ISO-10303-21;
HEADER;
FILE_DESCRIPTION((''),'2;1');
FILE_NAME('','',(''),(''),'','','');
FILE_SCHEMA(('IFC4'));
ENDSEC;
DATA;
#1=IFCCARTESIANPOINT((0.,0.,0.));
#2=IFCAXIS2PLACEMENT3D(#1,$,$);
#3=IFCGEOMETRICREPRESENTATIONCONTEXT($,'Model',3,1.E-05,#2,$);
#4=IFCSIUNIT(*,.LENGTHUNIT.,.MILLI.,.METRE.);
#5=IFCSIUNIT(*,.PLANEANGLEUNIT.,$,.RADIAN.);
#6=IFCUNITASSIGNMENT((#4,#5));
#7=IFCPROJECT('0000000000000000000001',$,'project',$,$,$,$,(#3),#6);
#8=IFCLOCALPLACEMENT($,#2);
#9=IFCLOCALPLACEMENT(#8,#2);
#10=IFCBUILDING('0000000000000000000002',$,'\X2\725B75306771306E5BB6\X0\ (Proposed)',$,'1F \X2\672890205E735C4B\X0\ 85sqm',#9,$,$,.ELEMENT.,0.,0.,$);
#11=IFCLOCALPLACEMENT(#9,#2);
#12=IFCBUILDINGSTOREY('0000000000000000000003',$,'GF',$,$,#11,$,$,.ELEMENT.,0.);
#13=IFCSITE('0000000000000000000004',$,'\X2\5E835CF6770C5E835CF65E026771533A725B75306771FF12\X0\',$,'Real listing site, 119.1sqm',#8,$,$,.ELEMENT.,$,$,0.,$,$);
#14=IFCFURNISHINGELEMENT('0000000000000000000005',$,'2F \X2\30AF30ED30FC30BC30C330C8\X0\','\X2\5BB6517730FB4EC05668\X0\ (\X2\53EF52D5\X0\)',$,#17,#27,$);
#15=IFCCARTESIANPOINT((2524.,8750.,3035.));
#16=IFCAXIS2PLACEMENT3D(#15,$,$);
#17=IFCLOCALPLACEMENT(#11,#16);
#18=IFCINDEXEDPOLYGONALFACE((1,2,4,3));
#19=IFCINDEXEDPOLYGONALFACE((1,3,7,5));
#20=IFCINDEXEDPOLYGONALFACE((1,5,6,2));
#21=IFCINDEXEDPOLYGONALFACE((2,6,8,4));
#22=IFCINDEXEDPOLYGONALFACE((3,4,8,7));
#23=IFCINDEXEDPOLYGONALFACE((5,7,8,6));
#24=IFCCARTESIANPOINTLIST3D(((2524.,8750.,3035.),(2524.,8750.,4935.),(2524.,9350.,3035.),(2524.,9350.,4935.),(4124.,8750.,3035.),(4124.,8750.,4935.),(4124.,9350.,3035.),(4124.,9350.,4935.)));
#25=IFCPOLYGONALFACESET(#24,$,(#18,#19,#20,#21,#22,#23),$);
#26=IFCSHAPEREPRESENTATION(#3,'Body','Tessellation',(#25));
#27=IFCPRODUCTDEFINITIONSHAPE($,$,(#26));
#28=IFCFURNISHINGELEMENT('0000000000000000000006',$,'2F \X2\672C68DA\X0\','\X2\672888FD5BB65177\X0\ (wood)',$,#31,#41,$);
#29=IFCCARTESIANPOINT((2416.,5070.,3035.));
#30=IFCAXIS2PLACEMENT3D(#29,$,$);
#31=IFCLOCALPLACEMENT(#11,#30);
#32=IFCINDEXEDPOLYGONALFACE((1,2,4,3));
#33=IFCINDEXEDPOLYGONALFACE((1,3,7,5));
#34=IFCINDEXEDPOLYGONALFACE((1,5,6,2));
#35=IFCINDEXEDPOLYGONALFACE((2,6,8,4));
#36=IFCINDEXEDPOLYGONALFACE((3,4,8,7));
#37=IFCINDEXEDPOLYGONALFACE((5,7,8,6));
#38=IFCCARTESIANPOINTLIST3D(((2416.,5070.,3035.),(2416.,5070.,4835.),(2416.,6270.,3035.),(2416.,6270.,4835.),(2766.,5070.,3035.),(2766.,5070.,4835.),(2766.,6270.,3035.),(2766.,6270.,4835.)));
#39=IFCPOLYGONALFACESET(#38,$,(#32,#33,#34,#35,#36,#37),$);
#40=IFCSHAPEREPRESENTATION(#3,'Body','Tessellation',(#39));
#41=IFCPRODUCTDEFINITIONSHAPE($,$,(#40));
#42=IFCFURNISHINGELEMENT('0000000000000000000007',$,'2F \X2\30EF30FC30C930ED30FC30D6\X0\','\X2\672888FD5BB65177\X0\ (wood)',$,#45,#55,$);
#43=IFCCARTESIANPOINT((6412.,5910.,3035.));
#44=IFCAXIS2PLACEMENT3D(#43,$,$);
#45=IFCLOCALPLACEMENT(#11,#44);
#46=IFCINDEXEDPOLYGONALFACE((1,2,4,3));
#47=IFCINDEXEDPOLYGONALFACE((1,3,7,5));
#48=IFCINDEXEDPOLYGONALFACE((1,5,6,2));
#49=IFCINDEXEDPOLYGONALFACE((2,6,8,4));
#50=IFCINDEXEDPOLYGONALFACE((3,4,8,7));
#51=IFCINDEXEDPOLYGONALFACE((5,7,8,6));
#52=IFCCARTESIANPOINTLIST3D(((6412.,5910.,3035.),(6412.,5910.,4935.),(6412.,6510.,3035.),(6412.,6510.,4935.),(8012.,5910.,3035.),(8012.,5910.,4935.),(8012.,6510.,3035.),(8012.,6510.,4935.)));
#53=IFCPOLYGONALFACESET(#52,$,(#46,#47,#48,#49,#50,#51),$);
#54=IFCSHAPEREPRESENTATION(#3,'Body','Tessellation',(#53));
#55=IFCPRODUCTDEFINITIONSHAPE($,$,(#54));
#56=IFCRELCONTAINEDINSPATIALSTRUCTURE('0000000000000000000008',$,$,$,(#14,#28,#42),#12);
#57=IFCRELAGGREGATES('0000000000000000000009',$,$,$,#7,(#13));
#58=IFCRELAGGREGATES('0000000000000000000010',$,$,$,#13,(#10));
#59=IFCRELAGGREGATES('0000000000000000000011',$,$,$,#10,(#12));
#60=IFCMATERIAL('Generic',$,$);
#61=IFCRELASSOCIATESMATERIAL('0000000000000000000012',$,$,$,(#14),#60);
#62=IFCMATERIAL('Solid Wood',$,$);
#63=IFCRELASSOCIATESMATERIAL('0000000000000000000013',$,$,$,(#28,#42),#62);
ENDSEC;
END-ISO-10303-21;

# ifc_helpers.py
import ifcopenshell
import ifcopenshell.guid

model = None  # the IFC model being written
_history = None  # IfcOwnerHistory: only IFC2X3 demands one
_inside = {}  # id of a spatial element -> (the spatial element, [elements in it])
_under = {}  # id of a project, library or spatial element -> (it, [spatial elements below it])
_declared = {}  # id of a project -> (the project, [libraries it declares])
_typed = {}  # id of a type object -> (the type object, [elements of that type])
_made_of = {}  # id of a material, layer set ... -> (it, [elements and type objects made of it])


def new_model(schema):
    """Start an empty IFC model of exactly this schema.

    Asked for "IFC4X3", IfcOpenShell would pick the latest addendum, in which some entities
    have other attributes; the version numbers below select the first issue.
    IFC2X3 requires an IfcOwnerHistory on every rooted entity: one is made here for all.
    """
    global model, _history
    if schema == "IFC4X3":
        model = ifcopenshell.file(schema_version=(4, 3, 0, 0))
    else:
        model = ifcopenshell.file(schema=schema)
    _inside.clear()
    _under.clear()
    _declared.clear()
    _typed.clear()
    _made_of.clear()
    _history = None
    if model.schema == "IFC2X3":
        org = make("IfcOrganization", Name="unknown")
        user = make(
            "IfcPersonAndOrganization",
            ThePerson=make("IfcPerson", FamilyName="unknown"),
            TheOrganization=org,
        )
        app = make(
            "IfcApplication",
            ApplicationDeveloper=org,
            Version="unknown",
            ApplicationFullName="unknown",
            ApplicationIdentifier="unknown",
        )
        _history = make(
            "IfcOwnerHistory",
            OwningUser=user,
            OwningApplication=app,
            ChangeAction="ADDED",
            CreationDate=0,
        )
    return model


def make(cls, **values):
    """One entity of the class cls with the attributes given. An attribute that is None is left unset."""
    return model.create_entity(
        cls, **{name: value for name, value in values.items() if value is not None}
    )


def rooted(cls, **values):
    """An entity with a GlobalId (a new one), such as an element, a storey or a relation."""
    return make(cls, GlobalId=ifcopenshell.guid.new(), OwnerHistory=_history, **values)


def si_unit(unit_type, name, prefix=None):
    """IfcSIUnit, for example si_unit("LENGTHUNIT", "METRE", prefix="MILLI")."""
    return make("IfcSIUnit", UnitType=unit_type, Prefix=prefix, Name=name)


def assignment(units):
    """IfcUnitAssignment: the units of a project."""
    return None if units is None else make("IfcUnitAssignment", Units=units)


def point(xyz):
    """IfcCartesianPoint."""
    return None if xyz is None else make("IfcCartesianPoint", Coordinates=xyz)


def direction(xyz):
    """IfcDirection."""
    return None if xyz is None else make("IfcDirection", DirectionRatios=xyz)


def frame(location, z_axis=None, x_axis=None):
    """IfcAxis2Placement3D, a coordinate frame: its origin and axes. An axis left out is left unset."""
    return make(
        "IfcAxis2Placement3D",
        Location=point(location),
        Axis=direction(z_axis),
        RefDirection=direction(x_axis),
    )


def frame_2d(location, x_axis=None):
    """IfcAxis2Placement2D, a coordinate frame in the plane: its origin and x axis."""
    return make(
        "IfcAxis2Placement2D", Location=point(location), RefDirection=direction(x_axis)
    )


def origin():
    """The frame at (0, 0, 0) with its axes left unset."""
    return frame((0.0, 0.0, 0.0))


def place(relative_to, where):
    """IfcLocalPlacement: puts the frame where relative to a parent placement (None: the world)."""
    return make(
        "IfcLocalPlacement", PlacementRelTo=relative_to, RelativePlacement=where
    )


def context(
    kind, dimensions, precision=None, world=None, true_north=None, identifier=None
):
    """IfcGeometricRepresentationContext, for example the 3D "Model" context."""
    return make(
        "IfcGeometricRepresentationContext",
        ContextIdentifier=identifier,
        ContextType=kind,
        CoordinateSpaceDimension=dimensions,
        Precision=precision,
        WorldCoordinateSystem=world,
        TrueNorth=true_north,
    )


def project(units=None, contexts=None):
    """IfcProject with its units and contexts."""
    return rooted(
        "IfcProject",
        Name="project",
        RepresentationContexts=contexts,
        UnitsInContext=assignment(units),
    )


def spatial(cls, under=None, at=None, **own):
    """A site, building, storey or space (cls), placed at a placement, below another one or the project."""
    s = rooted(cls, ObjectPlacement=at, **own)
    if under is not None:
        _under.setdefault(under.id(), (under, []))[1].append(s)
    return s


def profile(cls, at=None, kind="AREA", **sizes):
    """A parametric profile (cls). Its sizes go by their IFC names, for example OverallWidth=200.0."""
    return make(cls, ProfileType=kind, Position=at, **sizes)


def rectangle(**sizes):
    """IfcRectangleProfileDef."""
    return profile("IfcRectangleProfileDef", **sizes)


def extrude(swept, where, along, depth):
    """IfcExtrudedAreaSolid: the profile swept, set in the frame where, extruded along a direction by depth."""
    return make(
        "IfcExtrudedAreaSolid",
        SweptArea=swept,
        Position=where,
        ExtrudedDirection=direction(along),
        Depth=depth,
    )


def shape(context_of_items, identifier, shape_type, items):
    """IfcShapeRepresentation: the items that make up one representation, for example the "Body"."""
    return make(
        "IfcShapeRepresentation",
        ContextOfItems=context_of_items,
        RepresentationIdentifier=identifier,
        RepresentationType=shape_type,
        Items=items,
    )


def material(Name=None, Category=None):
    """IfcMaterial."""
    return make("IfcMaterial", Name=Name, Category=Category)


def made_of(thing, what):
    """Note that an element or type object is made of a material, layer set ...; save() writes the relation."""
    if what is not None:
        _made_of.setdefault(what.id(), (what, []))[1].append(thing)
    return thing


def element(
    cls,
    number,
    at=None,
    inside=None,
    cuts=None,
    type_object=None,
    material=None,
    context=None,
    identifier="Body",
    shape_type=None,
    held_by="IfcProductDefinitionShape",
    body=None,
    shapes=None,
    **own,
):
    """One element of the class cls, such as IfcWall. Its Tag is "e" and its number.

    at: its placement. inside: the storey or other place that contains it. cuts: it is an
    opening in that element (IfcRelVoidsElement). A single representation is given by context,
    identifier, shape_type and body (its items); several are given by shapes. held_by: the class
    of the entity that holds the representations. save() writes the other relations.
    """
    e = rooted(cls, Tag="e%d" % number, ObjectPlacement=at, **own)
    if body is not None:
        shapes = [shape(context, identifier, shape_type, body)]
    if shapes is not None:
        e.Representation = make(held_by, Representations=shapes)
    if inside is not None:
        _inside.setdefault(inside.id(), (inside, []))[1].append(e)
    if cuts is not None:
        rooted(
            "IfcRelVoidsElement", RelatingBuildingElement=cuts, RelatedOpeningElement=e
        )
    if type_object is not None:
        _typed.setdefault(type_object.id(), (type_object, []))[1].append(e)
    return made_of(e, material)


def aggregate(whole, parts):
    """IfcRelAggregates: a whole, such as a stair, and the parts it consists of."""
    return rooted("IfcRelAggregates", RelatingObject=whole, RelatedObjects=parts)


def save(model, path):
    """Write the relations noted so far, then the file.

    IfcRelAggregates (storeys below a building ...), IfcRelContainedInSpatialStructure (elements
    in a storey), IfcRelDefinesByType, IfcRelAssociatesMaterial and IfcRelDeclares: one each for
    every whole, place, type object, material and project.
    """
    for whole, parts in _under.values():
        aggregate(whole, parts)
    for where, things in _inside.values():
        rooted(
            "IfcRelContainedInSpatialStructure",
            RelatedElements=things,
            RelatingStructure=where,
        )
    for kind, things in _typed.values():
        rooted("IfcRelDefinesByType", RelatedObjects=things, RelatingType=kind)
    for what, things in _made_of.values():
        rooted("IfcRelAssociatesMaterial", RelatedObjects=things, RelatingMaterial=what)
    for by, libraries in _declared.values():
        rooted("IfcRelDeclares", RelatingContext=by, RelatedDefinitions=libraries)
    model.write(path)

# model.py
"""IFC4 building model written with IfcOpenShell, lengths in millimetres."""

from ifc_helpers import new_model, si_unit, frame, frame_2d, origin, place, context, project, spatial, rectangle, extrude, material, element, save


model = new_model("IFC4")

# Units and contexts
model_context = context("Model", 3, precision=1e-05, world=origin())
ifc_project = project(units=[si_unit("LENGTHUNIT", "METRE", prefix="MILLI"), si_unit("PLANEANGLEUNIT", "RADIAN")], contexts=[model_context])

# Site, building, storey
site_placement = place(None, origin())
site = spatial("IfcSite", under=ifc_project, at=site_placement, Name="広島県広島市東区牛田東２", ObjectType="Real listing site, 119.1sqm", CompositionType="ELEMENT", RefElevation=0.0)
building_placement = place(site_placement, origin())
building = spatial("IfcBuilding", under=site, at=building_placement, Name="牛田東の家 (Proposed)", ObjectType="1F 木造平屋 85sqm", CompositionType="ELEMENT", ElevationOfRefHeight=0.0, ElevationOfTerrain=0.0)
storey_placement = place(building_placement, origin())
storey = spatial("IfcBuildingStorey", under=building, at=storey_placement, Name="GF", CompositionType="ELEMENT", Elevation=0.0)

# Shared definitions
ifc_material_1 = material(Name="Solid Wood")

# Shared definitions
ifc_material_2 = material(Name="Generic")

# Furnishing elements
furnishing_1_placement = place(storey_placement, frame((2524.0, 8750.0, 3035.0)))
element("IfcFurnishingElement", 1, at=furnishing_1_placement, inside=storey, material=ifc_material_2, Name="2F クローゼット", Description="家具・什器 (可動)", context=model_context, shape_type="SweptSolid", body=[
    extrude(rectangle(XDim=1600.0, YDim=600.0, at=frame_2d((800.0, 300.0))), frame((2524.0, 8750.0, 3035.0)), (0.0, 0.0, 1.0), 1900.0),
])
furnishing_2_placement = place(storey_placement, frame((2416.0, 5070.0, 3035.0)))
element("IfcFurnishingElement", 2, at=furnishing_2_placement, inside=storey, material=ifc_material_1, Name="2F 本棚", Description="木製家具 (wood)", context=model_context, shape_type="SweptSolid", body=[
    extrude(rectangle(XDim=350.0, YDim=1200.0, at=frame_2d((175.0, 600.0))), frame((2416.0, 5070.0, 3035.0)), (0.0, 0.0, 1.0), 1800.0),
])
furnishing_3_placement = place(storey_placement, frame((6412.0, 5910.0, 3035.0)))
element("IfcFurnishingElement", 3, at=furnishing_3_placement, inside=storey, material=ifc_material_1, Name="2F ワードローブ", Description="木製家具 (wood)", context=model_context, shape_type="SweptSolid", body=[
    extrude(rectangle(XDim=1600.0, YDim=600.0, at=frame_2d((800.0, 300.0))), frame((6412.0, 5910.0, 3035.0)), (0.0, 0.0, 1.0), 1900.0),
])

save(model, "model.ifc")
